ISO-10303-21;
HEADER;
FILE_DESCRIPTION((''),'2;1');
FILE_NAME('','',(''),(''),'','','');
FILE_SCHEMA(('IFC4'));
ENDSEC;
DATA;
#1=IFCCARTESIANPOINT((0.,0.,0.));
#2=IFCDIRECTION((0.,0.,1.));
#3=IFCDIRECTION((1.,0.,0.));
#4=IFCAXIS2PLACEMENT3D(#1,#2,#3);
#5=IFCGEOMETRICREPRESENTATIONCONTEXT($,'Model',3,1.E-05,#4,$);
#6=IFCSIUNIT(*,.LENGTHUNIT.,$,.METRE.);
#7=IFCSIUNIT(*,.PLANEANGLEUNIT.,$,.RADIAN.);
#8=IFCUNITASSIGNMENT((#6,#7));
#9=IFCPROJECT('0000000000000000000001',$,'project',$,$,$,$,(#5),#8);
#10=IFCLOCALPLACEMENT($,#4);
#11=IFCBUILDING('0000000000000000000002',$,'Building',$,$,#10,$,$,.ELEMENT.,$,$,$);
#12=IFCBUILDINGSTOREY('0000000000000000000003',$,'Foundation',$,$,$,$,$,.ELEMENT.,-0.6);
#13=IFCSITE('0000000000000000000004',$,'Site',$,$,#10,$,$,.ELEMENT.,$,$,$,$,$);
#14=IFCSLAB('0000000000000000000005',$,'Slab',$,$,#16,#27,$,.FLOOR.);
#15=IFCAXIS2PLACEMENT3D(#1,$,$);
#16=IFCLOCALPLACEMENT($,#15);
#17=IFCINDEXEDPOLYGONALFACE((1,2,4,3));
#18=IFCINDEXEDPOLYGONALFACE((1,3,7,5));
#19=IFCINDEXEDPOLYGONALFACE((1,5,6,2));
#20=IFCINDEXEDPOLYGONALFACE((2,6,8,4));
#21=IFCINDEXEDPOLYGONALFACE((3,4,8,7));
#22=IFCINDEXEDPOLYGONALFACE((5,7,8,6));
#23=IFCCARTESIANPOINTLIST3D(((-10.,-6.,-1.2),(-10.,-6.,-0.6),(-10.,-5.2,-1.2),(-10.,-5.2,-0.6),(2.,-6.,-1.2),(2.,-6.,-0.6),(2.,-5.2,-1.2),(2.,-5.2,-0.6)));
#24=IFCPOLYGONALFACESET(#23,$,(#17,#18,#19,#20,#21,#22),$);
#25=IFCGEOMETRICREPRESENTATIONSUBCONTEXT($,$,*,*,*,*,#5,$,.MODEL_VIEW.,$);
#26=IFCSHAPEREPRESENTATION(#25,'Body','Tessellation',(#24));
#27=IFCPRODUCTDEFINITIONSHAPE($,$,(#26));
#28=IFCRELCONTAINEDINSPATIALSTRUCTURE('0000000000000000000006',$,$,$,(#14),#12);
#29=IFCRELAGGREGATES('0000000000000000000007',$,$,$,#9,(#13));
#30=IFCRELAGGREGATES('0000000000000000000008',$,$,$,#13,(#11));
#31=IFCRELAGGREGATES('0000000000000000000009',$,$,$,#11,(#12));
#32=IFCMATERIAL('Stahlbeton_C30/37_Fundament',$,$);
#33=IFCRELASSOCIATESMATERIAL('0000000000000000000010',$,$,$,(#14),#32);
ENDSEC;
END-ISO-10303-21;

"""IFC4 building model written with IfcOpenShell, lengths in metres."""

from ifc_helpers import new_model, si_unit, frame, frame_2d, origin, origin_with_axes, place, context, subcontext, project, spatial, rectangle, extrude, material, element, save


model = new_model("IFC4")

# Units and contexts
model_context = context("Model", 3, precision=1e-05, world=origin_with_axes())
sub_context = subcontext(model_context, None, None, "MODEL_VIEW")
ifc_project = project(units=[si_unit("LENGTHUNIT", "METRE"), si_unit("PLANEANGLEUNIT", "RADIAN")], contexts=[model_context])

# Site, building, storey
placement_1 = place(None, origin_with_axes())
site = spatial("IfcSite", under=ifc_project, at=placement_1, Name="Site", CompositionType="ELEMENT")
building = spatial("IfcBuilding", under=site, at=placement_1, Name="Building", CompositionType="ELEMENT")
storey = spatial("IfcBuildingStorey", under=building, Name="Foundation", CompositionType="ELEMENT", Elevation=-0.6)

# Slab
ifc_material = material(Name="Stahlbeton_C30/37_Fundament")
placement_2 = place(None, origin_with_axes())
placement_3 = place(placement_2, frame((0.0, 0.0, -0.6)))
slab_placement = place(placement_3, frame((-10.0, -6.0, -0.6)))
element("IfcSlab", 1, at=slab_placement, inside=storey, material=ifc_material, Name="Slab", PredefinedType="FLOOR", context=sub_context, shape_type="SweptSolid", body=[
    extrude(rectangle(XDim=12.0, YDim=0.8, at=frame_2d((6.0, 0.4))), origin(), (0.0, 0.0, 1.0), 0.6),
])

save(model, "model.ifc")
